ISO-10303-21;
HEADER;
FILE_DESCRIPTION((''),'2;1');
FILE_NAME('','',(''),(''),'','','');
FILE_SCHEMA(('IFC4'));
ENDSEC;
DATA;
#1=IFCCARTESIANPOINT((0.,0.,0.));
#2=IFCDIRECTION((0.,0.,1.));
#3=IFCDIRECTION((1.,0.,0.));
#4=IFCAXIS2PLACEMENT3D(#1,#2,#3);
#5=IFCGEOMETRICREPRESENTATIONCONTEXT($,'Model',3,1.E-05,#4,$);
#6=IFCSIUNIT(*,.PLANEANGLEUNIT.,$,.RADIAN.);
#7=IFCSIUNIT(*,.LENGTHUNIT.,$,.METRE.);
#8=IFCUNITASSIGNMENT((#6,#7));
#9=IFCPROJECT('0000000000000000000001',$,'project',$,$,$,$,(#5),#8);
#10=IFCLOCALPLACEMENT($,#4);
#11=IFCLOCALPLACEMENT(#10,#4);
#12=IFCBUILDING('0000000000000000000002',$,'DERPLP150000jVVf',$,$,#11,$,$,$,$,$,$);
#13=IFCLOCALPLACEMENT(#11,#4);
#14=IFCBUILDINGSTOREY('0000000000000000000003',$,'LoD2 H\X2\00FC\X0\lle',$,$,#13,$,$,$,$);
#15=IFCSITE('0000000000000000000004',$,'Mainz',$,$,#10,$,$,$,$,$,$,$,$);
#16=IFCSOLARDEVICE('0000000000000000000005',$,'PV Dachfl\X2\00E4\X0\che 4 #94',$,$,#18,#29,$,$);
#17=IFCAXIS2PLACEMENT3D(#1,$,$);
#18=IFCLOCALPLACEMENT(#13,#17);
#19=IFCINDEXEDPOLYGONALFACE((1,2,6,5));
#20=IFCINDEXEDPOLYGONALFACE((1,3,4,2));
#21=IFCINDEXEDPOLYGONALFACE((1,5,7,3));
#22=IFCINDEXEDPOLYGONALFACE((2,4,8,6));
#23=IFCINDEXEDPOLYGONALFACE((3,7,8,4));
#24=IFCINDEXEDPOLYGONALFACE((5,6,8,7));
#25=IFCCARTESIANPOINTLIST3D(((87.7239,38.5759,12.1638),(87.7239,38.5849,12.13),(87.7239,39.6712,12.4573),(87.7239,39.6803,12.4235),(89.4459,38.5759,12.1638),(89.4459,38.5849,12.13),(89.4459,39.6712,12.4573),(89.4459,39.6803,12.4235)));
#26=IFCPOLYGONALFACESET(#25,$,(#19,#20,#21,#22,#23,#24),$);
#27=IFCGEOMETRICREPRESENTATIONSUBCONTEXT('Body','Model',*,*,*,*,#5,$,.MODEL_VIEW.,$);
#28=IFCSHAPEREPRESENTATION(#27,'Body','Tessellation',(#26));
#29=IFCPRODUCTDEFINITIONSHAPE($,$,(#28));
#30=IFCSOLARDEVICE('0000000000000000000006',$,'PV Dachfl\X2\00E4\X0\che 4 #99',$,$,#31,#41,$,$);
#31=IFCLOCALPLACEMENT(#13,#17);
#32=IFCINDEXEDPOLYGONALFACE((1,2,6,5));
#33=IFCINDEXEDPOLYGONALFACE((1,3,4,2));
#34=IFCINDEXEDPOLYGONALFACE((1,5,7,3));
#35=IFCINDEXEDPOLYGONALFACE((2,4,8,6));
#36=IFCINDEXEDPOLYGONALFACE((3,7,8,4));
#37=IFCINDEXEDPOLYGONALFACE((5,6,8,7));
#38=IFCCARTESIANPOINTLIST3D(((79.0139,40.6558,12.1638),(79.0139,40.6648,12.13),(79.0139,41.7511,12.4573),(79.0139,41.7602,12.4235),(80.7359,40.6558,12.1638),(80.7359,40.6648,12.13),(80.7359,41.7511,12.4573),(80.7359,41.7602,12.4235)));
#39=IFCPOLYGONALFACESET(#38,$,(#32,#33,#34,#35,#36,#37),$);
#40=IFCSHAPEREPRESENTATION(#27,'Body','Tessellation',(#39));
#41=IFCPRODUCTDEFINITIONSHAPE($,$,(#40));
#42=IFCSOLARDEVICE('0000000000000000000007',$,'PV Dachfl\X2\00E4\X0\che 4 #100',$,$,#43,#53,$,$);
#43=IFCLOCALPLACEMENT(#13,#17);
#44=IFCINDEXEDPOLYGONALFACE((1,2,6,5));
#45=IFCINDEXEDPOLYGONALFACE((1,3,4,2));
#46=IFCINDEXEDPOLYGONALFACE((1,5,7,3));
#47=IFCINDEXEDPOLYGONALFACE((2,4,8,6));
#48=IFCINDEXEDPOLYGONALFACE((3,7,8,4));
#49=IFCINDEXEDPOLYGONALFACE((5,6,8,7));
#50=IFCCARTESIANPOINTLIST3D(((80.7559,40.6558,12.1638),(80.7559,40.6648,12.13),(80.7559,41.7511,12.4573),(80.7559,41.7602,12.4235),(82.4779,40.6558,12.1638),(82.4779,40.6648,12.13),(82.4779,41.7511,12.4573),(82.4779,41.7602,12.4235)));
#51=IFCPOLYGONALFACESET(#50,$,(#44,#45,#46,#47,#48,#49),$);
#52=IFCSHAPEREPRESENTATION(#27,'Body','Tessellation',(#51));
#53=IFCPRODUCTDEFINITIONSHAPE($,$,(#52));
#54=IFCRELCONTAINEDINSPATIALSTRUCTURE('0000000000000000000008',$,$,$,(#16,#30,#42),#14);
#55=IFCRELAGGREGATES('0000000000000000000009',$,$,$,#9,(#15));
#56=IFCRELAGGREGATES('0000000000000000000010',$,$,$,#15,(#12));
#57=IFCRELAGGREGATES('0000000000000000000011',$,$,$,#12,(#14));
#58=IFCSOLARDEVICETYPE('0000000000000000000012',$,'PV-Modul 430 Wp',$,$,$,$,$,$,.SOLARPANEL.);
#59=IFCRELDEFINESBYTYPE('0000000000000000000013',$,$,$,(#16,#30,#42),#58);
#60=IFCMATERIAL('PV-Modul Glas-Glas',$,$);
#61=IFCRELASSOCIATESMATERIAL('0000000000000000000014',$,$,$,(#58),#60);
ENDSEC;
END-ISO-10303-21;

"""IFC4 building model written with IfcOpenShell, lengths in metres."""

from ifc_helpers import new_model, si_unit, frame, frame_2d, origin, origin_with_axes, place, context, subcontext, project, spatial, rectangle, extrude, source, transform, mapped, material, type_object, type_shapes, element, save


model = new_model("IFC4")

# Units and contexts
model_context = context("Model", 3, precision=1e-05, world=origin_with_axes())
body_context = subcontext(model_context, "Body", "Model", "MODEL_VIEW")
ifc_project = project(units=[si_unit("PLANEANGLEUNIT", "RADIAN"), si_unit("LENGTHUNIT", "METRE")], contexts=[model_context])

# Site, building, storey
site_placement = place(None, origin_with_axes())
site = spatial("IfcSite", under=ifc_project, at=site_placement, Name="Mainz")
building_placement = place(site_placement, origin_with_axes())
building = spatial("IfcBuilding", under=site, at=building_placement, Name="DERPLP150000jVVf")
storey_placement = place(building_placement, origin_with_axes())
storey = spatial("IfcBuildingStorey", under=building, at=storey_placement, Name="LoD2 Hülle")

# Solar devices
ifc_material = material(Name="PV-Modul Glas-Glas")
solar_device_type = type_object("IfcSolarDeviceType", Name="PV-Modul 430 Wp", PredefinedType="SOLARPANEL", material=ifc_material)
shared_shape = source(origin_with_axes(), body_context, "Body", "SweptSolid", [
    extrude(rectangle(XDim=1.722, YDim=1.134, at=frame_2d((0.861, 0.567))), origin(), (0.0, 0.0, 1.0), 0.035),
])
type_shapes(solar_device_type, [shared_shape])
for number, where, z_axis, x_axis, name in (
    (1, (87.7239, 38.5849, 12.13), (0.0, -0.258819, 0.965926), (1.0, 0.0, 0.0), "PV Dachfläche 4 #94"),
    (2, (79.0139, 40.6648, 12.13), (0.0, -0.258819, 0.965926), (1.0, 0.0, 0.0), "PV Dachfläche 4 #99"),
    (3, (80.7559, 40.6648, 12.13), (0.0, -0.258819, 0.965926), (1.0, 0.0, 0.0), "PV Dachfläche 4 #100"),
):
    element("IfcSolarDevice", number, at=place(storey_placement, frame(where, z_axis=z_axis, x_axis=x_axis)), inside=storey, type_object=solar_device_type, Name=name, context=body_context, shape_type="MappedRepresentation", body=[
        mapped(shared_shape, transform((0.0, 0.0, 0.0), x_axis=(1.0, 0.0, 0.0), y_axis=(0.0, 1.0, 0.0), z_axis=(0.0, 0.0, 1.0), scale=1.0)),
    ])

save(model, "model.ifc")
